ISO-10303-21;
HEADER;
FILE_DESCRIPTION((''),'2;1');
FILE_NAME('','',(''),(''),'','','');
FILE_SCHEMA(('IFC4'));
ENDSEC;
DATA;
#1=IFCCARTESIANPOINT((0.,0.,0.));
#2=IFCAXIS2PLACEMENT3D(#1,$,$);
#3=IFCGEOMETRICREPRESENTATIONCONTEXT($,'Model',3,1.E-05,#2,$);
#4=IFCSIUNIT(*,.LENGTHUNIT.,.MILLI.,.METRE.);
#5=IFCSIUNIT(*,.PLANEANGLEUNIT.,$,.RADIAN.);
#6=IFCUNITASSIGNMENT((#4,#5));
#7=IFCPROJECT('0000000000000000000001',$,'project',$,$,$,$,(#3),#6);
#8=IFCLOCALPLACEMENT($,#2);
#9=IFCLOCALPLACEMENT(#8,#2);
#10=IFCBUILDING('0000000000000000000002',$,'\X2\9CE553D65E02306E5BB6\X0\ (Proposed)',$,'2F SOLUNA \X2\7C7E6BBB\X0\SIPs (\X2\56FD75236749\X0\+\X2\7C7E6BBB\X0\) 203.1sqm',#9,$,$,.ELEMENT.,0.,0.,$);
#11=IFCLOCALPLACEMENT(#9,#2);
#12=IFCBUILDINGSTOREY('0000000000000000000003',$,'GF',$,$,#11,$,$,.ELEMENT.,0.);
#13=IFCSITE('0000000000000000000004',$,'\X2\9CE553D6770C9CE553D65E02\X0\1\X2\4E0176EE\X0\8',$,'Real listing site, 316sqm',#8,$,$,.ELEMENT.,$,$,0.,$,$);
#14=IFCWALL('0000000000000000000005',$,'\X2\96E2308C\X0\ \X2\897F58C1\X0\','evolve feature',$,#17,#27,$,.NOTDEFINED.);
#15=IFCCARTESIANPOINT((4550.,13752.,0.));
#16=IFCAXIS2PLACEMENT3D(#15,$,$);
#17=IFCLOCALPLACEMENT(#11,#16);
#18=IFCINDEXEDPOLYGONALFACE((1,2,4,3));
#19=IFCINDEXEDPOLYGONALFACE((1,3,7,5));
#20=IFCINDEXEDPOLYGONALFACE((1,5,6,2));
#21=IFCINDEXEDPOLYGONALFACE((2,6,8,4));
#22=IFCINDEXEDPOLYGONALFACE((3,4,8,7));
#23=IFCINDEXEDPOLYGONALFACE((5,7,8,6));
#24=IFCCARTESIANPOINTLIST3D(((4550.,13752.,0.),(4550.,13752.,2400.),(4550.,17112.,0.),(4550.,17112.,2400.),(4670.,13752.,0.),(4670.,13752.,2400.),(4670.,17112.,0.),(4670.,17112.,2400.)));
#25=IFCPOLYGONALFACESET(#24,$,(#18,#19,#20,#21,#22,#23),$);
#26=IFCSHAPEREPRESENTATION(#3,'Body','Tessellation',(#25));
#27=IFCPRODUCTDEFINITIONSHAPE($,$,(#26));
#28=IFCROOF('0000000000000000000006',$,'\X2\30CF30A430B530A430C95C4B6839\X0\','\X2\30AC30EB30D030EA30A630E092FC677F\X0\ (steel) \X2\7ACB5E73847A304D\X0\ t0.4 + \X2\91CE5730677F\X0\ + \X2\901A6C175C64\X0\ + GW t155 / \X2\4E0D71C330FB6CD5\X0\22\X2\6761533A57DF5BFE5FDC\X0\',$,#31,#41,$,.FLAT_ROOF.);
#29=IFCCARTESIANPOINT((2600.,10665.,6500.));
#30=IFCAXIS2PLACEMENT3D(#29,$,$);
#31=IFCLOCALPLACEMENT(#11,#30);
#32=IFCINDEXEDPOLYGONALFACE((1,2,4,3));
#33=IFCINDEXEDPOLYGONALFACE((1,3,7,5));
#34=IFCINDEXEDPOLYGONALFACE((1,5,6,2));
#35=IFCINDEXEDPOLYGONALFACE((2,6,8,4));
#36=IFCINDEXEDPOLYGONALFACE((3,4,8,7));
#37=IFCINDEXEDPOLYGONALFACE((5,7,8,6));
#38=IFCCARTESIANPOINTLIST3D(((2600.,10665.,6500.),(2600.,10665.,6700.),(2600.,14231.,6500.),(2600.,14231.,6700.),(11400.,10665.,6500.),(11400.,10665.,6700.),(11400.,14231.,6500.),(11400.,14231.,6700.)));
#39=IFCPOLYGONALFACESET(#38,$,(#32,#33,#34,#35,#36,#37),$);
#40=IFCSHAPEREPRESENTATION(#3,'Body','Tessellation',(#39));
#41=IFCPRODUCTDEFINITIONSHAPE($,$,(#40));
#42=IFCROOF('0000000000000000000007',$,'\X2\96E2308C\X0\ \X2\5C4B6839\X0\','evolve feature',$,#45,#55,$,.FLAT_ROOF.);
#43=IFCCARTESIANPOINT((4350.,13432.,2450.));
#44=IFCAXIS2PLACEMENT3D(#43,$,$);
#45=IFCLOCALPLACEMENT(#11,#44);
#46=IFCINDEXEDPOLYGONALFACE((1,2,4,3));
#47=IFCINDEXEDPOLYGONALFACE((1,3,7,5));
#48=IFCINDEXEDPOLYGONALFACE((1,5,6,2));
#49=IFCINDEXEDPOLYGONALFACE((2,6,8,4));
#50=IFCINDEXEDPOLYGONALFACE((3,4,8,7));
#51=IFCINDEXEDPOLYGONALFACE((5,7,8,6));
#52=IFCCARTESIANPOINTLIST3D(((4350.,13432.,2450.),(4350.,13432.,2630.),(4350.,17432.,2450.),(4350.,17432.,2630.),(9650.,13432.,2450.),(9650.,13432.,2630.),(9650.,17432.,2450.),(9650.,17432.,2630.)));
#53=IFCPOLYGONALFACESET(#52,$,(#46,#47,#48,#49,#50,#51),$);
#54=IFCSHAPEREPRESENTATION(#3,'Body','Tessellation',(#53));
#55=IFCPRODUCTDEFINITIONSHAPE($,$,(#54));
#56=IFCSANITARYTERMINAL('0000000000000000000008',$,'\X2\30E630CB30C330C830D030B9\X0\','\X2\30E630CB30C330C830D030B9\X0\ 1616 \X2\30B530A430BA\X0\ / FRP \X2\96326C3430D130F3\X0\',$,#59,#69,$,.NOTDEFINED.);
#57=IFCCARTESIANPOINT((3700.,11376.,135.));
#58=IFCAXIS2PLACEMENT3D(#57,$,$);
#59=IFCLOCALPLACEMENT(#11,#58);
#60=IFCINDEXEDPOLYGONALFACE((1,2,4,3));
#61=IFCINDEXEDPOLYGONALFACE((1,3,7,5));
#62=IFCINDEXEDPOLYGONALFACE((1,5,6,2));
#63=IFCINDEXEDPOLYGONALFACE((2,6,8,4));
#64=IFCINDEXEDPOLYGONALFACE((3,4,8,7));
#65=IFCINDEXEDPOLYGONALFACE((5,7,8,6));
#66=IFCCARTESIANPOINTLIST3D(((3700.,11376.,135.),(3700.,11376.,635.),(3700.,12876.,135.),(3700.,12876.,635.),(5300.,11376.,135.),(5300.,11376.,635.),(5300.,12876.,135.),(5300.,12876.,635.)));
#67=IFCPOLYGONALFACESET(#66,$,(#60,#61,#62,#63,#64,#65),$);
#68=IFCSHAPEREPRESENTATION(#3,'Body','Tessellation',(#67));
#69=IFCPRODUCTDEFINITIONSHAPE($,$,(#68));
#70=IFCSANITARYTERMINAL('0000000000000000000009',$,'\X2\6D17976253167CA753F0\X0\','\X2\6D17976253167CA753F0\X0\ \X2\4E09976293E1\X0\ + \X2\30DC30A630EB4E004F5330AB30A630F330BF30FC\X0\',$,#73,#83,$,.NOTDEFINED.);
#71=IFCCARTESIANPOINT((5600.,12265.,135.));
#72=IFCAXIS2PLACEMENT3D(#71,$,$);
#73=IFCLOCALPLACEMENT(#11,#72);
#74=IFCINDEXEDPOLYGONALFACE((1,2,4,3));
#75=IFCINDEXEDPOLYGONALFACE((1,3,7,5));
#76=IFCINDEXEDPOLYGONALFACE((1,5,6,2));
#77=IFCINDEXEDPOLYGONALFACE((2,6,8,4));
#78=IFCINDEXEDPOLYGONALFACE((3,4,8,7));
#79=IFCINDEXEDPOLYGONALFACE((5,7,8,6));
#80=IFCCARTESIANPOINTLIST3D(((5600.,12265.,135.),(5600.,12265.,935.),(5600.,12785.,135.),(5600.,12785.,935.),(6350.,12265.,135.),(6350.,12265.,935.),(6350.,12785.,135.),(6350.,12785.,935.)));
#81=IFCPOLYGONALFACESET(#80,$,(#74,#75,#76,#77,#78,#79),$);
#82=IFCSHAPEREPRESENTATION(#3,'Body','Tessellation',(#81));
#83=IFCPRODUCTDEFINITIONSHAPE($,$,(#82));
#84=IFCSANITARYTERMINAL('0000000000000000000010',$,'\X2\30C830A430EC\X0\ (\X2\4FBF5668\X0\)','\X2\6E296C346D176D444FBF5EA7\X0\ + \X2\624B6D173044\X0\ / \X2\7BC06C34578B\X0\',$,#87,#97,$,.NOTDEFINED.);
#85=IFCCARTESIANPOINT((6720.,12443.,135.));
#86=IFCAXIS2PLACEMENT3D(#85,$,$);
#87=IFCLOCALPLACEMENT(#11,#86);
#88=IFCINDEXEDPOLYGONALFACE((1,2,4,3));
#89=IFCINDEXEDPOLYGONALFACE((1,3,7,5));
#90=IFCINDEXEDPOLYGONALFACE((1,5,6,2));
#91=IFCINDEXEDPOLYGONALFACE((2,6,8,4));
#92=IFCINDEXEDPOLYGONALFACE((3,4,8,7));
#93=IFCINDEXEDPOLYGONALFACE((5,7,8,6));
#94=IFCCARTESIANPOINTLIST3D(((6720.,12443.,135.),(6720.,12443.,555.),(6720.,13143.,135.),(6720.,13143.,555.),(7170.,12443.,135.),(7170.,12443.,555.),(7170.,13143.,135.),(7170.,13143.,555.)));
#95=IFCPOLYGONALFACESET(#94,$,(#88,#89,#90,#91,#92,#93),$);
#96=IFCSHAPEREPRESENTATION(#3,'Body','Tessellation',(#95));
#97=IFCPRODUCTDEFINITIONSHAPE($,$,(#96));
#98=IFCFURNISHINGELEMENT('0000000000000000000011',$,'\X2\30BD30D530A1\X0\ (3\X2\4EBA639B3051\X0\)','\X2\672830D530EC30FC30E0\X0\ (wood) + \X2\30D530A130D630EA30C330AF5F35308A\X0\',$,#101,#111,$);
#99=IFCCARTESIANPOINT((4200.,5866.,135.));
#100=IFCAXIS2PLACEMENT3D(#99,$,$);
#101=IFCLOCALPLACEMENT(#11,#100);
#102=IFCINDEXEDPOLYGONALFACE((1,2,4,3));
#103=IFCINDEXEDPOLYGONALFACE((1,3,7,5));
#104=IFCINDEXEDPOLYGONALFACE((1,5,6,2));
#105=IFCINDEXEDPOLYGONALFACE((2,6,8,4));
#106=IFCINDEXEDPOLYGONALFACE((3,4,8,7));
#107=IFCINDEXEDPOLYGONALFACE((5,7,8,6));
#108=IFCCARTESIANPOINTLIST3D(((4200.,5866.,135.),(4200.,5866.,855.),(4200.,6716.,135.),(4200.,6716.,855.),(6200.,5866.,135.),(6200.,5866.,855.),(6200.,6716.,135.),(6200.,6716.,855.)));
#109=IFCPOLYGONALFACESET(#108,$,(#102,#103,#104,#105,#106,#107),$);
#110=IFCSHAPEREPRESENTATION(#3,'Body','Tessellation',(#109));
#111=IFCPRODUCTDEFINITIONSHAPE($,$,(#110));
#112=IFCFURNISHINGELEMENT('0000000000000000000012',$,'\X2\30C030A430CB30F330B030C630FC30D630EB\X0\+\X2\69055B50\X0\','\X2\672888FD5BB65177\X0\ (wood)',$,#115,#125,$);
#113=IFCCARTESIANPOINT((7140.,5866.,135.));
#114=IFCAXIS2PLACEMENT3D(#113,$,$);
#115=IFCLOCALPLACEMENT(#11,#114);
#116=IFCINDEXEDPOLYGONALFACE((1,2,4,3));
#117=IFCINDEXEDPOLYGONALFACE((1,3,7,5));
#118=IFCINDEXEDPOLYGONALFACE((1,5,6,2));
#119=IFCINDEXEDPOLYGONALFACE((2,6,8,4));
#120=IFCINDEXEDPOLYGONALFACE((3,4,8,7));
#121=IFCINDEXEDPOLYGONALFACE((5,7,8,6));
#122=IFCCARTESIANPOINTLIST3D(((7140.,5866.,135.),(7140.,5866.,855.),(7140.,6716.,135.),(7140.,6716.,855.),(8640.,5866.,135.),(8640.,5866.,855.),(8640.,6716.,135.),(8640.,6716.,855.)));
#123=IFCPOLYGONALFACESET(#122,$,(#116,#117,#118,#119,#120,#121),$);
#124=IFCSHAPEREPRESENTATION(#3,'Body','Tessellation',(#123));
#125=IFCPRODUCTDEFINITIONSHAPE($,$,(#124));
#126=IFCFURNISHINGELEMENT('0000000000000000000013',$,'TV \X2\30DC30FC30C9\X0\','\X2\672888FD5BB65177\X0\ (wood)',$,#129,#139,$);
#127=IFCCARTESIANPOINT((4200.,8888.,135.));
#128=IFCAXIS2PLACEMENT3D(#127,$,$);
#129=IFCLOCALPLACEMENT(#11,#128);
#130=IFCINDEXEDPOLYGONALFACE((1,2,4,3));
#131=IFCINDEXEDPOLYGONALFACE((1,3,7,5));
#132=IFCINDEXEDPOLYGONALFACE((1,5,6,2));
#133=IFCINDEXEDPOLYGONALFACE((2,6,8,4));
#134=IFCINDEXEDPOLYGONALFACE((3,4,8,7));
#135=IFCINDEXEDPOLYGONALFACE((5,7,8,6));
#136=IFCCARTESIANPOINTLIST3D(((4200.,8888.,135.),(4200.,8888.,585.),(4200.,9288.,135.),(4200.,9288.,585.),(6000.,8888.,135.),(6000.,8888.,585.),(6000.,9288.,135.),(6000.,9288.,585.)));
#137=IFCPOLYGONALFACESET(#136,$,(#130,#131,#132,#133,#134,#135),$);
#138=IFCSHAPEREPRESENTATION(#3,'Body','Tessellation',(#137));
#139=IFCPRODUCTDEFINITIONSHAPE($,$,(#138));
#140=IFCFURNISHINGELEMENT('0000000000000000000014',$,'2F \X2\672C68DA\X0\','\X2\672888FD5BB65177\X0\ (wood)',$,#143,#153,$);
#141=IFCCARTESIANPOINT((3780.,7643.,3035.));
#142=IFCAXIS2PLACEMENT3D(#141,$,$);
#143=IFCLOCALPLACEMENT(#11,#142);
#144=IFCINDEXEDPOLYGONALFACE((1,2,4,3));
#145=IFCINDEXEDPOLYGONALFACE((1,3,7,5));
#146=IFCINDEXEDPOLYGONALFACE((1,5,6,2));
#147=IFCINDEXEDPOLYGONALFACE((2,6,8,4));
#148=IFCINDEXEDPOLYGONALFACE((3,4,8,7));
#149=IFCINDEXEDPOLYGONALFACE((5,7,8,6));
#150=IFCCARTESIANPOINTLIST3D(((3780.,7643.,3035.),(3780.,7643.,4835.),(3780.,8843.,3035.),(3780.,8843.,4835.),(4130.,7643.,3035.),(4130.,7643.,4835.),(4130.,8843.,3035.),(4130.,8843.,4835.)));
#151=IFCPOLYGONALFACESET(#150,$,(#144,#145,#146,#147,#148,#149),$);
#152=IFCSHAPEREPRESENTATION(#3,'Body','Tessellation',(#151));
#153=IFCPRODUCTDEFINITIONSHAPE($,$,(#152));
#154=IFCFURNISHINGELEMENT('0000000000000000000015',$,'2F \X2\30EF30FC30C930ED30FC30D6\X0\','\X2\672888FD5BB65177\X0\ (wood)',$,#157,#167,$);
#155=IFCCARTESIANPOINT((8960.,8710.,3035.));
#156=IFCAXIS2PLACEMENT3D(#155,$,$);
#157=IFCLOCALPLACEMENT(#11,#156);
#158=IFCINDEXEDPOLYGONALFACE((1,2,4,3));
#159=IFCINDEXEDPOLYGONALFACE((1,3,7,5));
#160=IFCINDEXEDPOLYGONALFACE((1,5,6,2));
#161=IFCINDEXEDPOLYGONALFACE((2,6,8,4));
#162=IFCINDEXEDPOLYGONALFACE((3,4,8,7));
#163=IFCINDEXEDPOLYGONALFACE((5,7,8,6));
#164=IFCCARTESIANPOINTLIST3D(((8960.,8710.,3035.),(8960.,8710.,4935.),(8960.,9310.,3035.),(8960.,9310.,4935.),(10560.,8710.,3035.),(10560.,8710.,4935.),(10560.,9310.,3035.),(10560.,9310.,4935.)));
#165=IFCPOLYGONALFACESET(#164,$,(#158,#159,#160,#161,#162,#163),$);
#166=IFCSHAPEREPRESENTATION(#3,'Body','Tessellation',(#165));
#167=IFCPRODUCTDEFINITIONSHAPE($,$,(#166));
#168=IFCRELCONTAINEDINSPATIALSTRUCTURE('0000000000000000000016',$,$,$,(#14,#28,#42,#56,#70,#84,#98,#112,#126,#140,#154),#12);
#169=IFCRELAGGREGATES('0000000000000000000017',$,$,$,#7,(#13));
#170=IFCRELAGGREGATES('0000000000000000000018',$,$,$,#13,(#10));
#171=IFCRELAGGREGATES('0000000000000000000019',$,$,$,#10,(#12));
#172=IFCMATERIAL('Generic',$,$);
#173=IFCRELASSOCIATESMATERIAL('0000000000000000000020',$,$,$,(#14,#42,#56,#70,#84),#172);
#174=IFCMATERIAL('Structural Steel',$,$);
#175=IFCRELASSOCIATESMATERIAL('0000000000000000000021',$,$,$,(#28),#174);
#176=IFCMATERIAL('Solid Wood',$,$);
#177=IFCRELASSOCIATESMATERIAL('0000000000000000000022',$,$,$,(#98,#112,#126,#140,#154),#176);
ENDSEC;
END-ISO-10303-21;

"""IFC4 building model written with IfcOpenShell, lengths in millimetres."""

from ifc_helpers import new_model, si_unit, frame, frame_2d, origin, place, context, project, spatial, rectangle, extrude, material, element, save


model = new_model("IFC4")

# Units and contexts
model_context = context("Model", 3, precision=1e-05, world=origin())
ifc_project = project(units=[si_unit("LENGTHUNIT", "METRE", prefix="MILLI"), si_unit("PLANEANGLEUNIT", "RADIAN")], contexts=[model_context])

# Site, building, storey
site_placement = place(None, origin())
site = spatial("IfcSite", under=ifc_project, at=site_placement, Name="鳥取県鳥取市1丁目8", ObjectType="Real listing site, 316sqm", CompositionType="ELEMENT", RefElevation=0.0)
building_placement = place(site_placement, origin())
building = spatial("IfcBuilding", under=site, at=building_placement, Name="鳥取市の家 (Proposed)", ObjectType="2F SOLUNA 籾殻SIPs (国産杉+籾殻) 203.1sqm", CompositionType="ELEMENT", ElevationOfRefHeight=0.0, ElevationOfTerrain=0.0)
storey_placement = place(building_placement, origin())
storey = spatial("IfcBuildingStorey", under=building, at=storey_placement, Name="GF", CompositionType="ELEMENT", Elevation=0.0)

# Shared definitions
ifc_material_1 = material(Name="Generic")

# Shared definitions
ifc_material_2 = material(Name="Solid Wood")

# Wall
wall_1_placement = place(storey_placement, frame((4550.0, 13752.0, 0.0)))
element("IfcWall", 1, at=wall_1_placement, inside=storey, material=ifc_material_1, Name="離れ 西壁", Description="evolve feature", PredefinedType="NOTDEFINED", context=model_context, shape_type="SweptSolid", body=[
    extrude(rectangle(XDim=120.0, YDim=3360.0, at=frame_2d((60.0, 1680.0))), frame((4550.0, 13752.0, 0.0)), (0.0, 0.0, 1.0), 2400.0),
])

# Roofs
ifc_material_3 = material(Name="Structural Steel")
roof_1_placement = place(storey_placement, frame((2600.0, 10665.0, 6500.0)))
element("IfcRoof", 2, at=roof_1_placement, inside=storey, material=ifc_material_3, Name="ハイサイド屋根", Description="ガルバリウム鋼板 (steel) 立平葺き t0.4 + 野地板 + 通気層 + GW t155 / 不燃・法22条区域対応", PredefinedType="FLAT_ROOF", context=model_context, shape_type="SweptSolid", body=[
    extrude(rectangle(XDim=8800.0, YDim=3566.0, at=frame_2d((4400.0, 1783.0))), frame((2600.0, 10665.0, 6500.0)), (0.0, 0.0, 1.0), 200.0),
])
roof_2_placement = place(storey_placement, frame((4350.0, 13432.0, 2450.0)))
element("IfcRoof", 3, at=roof_2_placement, inside=storey, material=ifc_material_1, Name="離れ 屋根", Description="evolve feature", PredefinedType="FLAT_ROOF", context=model_context, shape_type="SweptSolid", body=[
    extrude(rectangle(XDim=5300.0, YDim=4000.0, at=frame_2d((2650.0, 2000.0))), frame((4350.0, 13432.0, 2450.0)), (0.0, 0.0, 1.0), 180.0),
])

# Sanitary terminals
sanitary_terminal_1_placement = place(storey_placement, frame((3700.0, 11376.0, 135.0)))
element("IfcSanitaryTerminal", 4, at=sanitary_terminal_1_placement, inside=storey, material=ifc_material_1, Name="ユニットバス", Description="ユニットバス 1616 サイズ / FRP 防水パン", PredefinedType="NOTDEFINED", context=model_context, shape_type="SweptSolid", body=[
    extrude(rectangle(XDim=1600.0, YDim=1500.0, at=frame_2d((800.0, 750.0))), frame((3700.0, 11376.0, 135.0)), (0.0, 0.0, 1.0), 500.0),
])
sanitary_terminal_2_placement = place(storey_placement, frame((5600.0, 12265.0, 135.0)))
element("IfcSanitaryTerminal", 5, at=sanitary_terminal_2_placement, inside=storey, material=ifc_material_1, Name="洗面化粧台", Description="洗面化粧台 三面鏡 + ボウル一体カウンター", PredefinedType="NOTDEFINED", context=model_context, shape_type="SweptSolid", body=[
    extrude(rectangle(XDim=750.0, YDim=520.0, at=frame_2d((375.0, 260.0))), frame((5600.0, 12265.0, 135.0)), (0.0, 0.0, 1.0), 800.0),
])
sanitary_terminal_3_placement = place(storey_placement, frame((6720.0, 12443.0, 135.0)))
element("IfcSanitaryTerminal", 6, at=sanitary_terminal_3_placement, inside=storey, material=ifc_material_1, Name="トイレ (便器)", Description="温水洗浄便座 + 手洗い / 節水型", PredefinedType="NOTDEFINED", context=model_context, shape_type="SweptSolid", body=[
    extrude(rectangle(XDim=450.0, YDim=700.0, at=frame_2d((225.0, 350.0))), frame((6720.0, 12443.0, 135.0)), (0.0, 0.0, 1.0), 420.0),
])

# Furnishing elements
furnishing_1_placement = place(storey_placement, frame((4200.0, 5866.0, 135.0)))
element("IfcFurnishingElement", 7, at=furnishing_1_placement, inside=storey, material=ifc_material_2, Name="ソファ (3人掛け)", Description="木フレーム (wood) + ファブリック張り", context=model_context, shape_type="SweptSolid", body=[
    extrude(rectangle(XDim=2000.0, YDim=850.0, at=frame_2d((1000.0, 425.0))), frame((4200.0, 5866.0, 135.0)), (0.0, 0.0, 1.0), 720.0),
])
furnishing_2_placement = place(storey_placement, frame((7140.0, 5866.0, 135.0)))
element("IfcFurnishingElement", 8, at=furnishing_2_placement, inside=storey, material=ifc_material_2, Name="ダイニングテーブル+椅子", Description="木製家具 (wood)", context=model_context, shape_type="SweptSolid", body=[
    extrude(rectangle(XDim=1500.0, YDim=850.0, at=frame_2d((750.0, 425.0))), frame((7140.0, 5866.0, 135.0)), (0.0, 0.0, 1.0), 720.0),
])
furnishing_3_placement = place(storey_placement, frame((4200.0, 8888.0, 135.0)))
element("IfcFurnishingElement", 9, at=furnishing_3_placement, inside=storey, material=ifc_material_2, Name="TV ボード", Description="木製家具 (wood)", context=model_context, shape_type="SweptSolid", body=[
    extrude(rectangle(XDim=1800.0, YDim=400.0, at=frame_2d((900.0, 200.0))), frame((4200.0, 8888.0, 135.0)), (0.0, 0.0, 1.0), 450.0),
])
furnishing_4_placement = place(storey_placement, frame((3780.0, 7643.0, 3035.0)))
element("IfcFurnishingElement", 10, at=furnishing_4_placement, inside=storey, material=ifc_material_2, Name="2F 本棚", Description="木製家具 (wood)", context=model_context, shape_type="SweptSolid", body=[
    extrude(rectangle(XDim=350.0, YDim=1200.0, at=frame_2d((175.0, 600.0))), frame((3780.0, 7643.0, 3035.0)), (0.0, 0.0, 1.0), 1800.0),
])
furnishing_5_placement = place(storey_placement, frame((8960.0, 8710.0, 3035.0)))
element("IfcFurnishingElement", 11, at=furnishing_5_placement, inside=storey, material=ifc_material_2, Name="2F ワードローブ", Description="木製家具 (wood)", context=model_context, shape_type="SweptSolid", body=[
    extrude(rectangle(XDim=1600.0, YDim=600.0, at=frame_2d((800.0, 300.0))), frame((8960.0, 8710.0, 3035.0)), (0.0, 0.0, 1.0), 1900.0),
])

save(model, "model.ifc")
